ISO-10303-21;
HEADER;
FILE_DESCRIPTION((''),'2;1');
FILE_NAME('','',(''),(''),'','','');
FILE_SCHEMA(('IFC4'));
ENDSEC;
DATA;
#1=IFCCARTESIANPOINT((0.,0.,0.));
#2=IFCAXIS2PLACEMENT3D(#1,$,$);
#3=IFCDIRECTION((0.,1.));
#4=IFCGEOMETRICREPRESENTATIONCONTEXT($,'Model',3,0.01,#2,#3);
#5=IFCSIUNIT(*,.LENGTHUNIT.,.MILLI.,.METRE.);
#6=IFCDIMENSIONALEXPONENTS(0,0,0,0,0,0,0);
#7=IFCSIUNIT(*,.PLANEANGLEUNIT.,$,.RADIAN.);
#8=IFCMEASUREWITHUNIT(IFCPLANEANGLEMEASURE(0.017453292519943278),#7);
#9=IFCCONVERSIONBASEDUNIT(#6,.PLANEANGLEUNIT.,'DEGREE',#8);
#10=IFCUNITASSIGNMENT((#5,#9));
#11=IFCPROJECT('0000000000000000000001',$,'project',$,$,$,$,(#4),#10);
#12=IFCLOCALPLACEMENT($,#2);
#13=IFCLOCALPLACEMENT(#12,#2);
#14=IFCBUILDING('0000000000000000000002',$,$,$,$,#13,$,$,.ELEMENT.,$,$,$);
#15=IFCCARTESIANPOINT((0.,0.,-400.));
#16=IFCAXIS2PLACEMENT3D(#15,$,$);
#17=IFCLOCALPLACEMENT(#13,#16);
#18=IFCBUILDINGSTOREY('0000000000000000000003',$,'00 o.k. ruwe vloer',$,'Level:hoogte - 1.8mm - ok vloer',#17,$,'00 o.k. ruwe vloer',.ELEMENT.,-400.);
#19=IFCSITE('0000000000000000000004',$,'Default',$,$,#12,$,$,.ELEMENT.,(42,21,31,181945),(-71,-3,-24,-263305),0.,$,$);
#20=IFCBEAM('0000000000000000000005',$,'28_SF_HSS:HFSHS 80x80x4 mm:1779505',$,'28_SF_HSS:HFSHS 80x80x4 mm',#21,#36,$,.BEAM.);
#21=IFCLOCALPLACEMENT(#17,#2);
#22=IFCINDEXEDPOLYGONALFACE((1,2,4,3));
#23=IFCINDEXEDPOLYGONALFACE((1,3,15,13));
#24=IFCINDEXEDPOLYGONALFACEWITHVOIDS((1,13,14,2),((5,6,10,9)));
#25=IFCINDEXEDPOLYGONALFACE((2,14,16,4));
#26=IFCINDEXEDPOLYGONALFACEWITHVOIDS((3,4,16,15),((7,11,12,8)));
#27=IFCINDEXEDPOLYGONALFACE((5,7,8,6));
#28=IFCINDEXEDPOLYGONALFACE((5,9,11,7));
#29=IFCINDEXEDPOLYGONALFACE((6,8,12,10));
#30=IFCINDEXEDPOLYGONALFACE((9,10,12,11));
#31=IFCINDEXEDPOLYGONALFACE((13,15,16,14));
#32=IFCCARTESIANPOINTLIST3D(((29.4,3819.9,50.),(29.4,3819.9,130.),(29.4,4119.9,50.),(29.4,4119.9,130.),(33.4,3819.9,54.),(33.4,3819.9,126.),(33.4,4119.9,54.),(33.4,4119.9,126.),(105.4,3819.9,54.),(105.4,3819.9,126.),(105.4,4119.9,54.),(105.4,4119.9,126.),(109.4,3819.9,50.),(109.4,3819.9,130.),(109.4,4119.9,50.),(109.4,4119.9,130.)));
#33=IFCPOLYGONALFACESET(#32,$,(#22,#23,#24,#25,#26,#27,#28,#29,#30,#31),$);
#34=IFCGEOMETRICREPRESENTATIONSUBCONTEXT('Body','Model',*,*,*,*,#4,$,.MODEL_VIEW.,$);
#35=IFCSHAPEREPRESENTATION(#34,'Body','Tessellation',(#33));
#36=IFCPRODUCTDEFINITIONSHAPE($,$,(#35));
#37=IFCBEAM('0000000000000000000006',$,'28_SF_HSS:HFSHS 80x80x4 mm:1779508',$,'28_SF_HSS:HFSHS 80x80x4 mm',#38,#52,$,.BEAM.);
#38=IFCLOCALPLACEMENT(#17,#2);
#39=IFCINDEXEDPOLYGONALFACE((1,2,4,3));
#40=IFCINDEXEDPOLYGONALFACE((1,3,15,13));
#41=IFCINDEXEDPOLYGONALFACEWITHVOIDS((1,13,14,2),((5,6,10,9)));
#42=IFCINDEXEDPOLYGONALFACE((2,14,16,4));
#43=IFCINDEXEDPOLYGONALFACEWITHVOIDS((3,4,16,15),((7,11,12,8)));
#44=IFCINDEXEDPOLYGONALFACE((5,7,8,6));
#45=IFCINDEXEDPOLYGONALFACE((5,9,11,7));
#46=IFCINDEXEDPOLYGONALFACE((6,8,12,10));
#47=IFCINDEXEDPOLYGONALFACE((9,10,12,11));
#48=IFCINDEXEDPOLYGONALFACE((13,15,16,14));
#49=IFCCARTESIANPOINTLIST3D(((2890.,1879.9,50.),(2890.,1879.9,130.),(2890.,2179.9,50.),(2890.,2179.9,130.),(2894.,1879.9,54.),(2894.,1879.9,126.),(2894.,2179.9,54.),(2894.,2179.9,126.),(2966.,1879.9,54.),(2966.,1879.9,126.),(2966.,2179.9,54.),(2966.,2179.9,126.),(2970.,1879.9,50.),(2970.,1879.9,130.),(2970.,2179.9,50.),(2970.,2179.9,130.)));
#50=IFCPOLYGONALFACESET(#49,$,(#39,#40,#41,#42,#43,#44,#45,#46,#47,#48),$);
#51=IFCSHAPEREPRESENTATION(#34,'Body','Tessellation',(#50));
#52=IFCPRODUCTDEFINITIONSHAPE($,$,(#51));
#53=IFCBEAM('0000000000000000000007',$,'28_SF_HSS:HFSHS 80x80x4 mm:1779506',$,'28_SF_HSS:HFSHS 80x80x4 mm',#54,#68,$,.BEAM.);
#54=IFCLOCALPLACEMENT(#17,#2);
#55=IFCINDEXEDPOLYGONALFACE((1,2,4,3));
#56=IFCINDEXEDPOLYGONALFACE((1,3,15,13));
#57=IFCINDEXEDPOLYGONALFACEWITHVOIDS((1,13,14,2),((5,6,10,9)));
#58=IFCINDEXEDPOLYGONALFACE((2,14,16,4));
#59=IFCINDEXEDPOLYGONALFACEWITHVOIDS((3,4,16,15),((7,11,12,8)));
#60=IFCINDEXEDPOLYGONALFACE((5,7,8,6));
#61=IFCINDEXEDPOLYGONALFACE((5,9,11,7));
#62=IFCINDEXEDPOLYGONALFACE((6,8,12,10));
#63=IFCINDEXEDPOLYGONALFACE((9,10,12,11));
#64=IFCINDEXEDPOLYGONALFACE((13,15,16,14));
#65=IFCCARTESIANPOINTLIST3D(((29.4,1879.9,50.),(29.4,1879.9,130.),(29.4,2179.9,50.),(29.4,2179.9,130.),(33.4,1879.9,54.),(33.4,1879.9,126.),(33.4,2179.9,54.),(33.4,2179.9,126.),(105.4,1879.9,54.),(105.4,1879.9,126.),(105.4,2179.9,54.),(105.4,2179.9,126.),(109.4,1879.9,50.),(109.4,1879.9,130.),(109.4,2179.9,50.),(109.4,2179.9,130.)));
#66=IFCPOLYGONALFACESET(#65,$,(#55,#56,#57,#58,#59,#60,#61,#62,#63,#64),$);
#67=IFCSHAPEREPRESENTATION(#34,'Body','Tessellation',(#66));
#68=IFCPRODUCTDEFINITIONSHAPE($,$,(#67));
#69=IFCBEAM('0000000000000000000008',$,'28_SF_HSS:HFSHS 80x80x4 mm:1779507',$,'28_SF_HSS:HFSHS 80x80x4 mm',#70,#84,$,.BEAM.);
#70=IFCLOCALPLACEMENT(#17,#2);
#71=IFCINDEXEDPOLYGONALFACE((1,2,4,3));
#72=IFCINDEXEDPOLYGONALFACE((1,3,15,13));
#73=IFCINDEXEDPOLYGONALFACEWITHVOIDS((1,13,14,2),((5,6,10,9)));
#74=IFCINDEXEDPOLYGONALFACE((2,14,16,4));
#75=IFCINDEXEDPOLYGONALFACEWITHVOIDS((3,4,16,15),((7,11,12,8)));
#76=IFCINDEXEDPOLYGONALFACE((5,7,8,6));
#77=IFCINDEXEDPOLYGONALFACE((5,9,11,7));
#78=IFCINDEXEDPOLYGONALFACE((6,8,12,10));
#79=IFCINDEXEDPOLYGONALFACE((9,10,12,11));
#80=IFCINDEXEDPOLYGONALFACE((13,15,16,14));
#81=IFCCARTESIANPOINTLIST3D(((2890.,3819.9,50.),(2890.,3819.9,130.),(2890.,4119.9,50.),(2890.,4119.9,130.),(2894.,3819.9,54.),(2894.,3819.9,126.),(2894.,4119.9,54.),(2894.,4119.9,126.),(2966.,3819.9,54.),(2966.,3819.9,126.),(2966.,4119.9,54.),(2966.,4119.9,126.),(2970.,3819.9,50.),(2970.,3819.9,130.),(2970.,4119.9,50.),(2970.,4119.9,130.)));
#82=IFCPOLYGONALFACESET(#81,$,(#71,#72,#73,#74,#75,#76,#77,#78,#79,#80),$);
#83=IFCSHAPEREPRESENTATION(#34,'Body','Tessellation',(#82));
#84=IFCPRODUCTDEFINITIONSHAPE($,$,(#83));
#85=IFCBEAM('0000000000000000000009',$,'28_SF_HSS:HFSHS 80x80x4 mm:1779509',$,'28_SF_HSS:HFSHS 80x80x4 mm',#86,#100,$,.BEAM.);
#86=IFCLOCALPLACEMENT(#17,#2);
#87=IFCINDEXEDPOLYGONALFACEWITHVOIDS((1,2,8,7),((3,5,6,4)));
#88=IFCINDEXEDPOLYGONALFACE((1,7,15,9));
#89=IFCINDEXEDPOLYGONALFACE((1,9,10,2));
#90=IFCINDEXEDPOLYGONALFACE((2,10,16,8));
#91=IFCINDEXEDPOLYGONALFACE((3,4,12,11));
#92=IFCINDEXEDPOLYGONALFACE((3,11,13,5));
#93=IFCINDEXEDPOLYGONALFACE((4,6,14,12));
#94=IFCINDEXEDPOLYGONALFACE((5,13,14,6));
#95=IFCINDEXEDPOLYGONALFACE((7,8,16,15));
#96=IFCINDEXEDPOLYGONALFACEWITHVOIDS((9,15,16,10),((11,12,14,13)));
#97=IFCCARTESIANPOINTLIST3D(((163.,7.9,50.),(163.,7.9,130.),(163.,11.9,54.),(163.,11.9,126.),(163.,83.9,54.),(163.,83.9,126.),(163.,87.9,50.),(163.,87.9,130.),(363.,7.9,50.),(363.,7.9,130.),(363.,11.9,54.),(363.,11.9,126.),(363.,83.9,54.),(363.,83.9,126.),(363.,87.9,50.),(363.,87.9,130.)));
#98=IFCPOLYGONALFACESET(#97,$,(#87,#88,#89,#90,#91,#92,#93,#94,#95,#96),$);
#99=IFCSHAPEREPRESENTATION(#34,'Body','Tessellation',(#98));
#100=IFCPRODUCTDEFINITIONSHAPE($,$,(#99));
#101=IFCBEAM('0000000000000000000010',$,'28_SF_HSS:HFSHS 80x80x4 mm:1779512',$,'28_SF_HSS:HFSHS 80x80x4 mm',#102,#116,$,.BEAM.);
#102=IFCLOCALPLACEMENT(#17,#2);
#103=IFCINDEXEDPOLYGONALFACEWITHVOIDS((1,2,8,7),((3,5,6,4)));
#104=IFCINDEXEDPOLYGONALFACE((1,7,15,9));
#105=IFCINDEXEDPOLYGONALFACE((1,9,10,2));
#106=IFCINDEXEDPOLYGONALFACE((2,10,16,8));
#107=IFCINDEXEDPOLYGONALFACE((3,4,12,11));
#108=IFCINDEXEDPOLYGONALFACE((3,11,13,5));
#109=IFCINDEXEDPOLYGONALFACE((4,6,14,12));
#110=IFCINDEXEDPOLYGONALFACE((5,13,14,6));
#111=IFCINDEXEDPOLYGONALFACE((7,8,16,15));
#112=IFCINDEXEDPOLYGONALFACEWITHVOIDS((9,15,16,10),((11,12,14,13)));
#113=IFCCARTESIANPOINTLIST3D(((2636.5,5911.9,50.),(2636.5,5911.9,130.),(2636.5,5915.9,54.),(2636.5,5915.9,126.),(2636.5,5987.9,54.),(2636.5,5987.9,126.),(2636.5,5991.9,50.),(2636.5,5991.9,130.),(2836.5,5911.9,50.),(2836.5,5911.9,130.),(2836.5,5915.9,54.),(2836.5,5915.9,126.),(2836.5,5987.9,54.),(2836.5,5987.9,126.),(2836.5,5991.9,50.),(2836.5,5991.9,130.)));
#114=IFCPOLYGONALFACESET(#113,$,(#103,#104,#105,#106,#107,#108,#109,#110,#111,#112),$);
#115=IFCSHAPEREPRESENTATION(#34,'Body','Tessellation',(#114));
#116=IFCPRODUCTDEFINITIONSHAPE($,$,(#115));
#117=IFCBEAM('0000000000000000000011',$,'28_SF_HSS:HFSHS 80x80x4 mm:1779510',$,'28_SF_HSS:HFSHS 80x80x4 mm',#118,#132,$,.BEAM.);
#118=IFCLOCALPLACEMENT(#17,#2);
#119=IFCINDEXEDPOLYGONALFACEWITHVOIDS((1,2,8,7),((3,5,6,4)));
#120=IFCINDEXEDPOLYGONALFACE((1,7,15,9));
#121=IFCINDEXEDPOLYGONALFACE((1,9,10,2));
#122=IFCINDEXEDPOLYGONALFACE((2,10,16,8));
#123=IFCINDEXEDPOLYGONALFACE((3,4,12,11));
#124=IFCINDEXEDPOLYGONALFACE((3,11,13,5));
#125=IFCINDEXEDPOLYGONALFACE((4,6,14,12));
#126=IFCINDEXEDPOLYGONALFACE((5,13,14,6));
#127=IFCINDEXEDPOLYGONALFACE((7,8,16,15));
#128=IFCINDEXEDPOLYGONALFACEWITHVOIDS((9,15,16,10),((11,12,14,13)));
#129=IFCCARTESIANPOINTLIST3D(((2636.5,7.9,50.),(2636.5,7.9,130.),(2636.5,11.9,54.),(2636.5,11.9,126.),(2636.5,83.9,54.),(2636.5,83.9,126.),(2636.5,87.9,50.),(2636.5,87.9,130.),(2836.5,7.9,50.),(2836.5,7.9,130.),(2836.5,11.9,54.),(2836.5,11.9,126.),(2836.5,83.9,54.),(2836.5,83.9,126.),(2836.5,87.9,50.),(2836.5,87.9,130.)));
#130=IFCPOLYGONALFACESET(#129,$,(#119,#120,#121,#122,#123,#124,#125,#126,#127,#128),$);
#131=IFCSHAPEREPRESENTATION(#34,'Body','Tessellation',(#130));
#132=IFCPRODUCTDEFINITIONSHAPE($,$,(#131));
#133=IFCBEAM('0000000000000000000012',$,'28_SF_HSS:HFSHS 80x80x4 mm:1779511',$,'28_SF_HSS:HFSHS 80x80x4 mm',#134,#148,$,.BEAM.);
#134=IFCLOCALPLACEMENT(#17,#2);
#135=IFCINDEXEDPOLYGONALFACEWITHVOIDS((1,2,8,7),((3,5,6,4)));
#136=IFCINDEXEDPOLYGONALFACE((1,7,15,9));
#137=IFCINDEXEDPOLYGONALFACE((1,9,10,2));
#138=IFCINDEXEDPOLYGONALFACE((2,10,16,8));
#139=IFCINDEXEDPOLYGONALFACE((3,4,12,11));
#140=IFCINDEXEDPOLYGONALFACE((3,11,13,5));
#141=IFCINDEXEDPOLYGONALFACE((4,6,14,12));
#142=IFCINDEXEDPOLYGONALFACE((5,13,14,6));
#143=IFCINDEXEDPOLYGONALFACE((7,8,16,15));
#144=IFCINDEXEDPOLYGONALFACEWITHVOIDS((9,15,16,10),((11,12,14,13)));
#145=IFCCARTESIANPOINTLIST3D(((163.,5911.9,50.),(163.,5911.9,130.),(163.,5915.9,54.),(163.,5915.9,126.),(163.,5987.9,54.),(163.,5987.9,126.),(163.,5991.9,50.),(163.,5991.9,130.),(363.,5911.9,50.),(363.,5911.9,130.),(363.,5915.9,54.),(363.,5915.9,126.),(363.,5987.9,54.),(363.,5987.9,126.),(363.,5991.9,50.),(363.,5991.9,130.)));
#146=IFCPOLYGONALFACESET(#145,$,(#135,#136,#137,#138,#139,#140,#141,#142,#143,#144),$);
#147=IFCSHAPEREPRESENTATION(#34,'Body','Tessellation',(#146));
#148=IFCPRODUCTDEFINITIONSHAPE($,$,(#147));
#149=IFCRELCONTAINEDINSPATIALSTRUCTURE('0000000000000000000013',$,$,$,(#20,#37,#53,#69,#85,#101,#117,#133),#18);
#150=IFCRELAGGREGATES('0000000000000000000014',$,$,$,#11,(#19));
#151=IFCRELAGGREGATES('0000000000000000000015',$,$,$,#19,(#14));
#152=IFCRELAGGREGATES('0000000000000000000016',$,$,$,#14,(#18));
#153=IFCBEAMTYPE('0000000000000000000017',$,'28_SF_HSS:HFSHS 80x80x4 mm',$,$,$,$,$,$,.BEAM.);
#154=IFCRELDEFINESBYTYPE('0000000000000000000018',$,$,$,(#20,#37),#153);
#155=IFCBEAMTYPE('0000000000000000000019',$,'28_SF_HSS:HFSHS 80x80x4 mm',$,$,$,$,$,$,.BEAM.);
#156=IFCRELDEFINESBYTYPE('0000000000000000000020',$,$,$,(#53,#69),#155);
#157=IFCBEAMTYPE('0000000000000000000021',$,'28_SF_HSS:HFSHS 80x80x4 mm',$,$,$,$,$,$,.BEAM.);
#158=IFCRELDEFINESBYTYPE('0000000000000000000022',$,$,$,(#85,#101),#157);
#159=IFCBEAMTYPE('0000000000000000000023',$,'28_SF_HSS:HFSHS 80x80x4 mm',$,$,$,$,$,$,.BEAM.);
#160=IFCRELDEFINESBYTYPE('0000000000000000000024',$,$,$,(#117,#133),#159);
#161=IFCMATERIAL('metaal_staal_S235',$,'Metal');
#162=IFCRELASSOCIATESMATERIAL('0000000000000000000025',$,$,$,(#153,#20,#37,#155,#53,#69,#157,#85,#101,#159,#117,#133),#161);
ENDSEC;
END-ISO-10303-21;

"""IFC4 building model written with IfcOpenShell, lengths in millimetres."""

from ifc_helpers import new_model, entity, si_unit, converted_unit, direction, frame, origin, place, context, subcontext, project, spatial, indexed_curve, outline, extrude, source, transform, mapped, material, type_object, type_shapes, element, save


model = new_model("IFC4")

# Units and contexts
model_context = context("Model", 3, precision=0.01, world=origin(), true_north=direction((0.0, 1.0)))
body_context = subcontext(model_context, "Body", "Model", "MODEL_VIEW")
ifc_project = project(units=[si_unit("LENGTHUNIT", "METRE", prefix="MILLI"), converted_unit("PLANEANGLEUNIT", "DEGREE", entity("IfcPlaneAngleMeasure", 0.017453292519943278), si_unit("PLANEANGLEUNIT", "RADIAN"), dimensions=[0, 0, 0, 0, 0, 0, 0])], contexts=[model_context])

# Site, building, storey
site_placement = place(None, origin())
site = spatial("IfcSite", under=ifc_project, at=site_placement, Name="Default", CompositionType="ELEMENT", RefLatitude=(42, 21, 31, 181945), RefLongitude=(-71, -3, -24, -263305), RefElevation=0.0)
building_placement = place(site_placement, origin())
building = spatial("IfcBuilding", under=site, at=building_placement, CompositionType="ELEMENT")
storey_placement = place(building_placement, frame((0.0, 0.0, -400.0)))
storey = spatial("IfcBuildingStorey", under=building, at=storey_placement, Name="00 o.k. ruwe vloer", ObjectType="Level:hoogte - 1.8mm - ok vloer", LongName="00 o.k. ruwe vloer", CompositionType="ELEMENT", Elevation=-400.0)

# Shared definitions
ifc_material = material(Name="metaal_staal_S235", Category="Metal")

# Beams
beam_type_1 = type_object("IfcBeamType", Name="28_SF_HSS:HFSHS 80x80x4 mm", PredefinedType="BEAM", material=ifc_material)
shared_shape_1 = source(origin(), body_context, "Body", "SweptSolid", [
    extrude(outline(indexed_curve([(-40.0, -40.0), (40.0, -40.0), (40.0, 40.0), (-40.0, 40.0), (-40.0, -40.0)], self_intersect=False), holes=[indexed_curve([(-36.0, -36.0), (-36.0, 36.0), (36.0, 36.0), (36.0, -36.0), (-36.0, -36.0)], self_intersect=False)]), frame((-150.0, 0.0, 0.0), z_axis=(1.0, 0.0, 0.0), x_axis=(0.0, -1.0, 0.0)), (0.0, 0.0, 1.0), 300.0),
])
type_shapes(beam_type_1, [shared_shape_1])
for number, where, z_axis, x_axis, name in (
    (1, (69.4, 3969.9, 90.0), (0.0, 0.0, 1.0), (0.0, 1.0, 0.0), "28_SF_HSS:HFSHS 80x80x4 mm:1779505"),
    (2, (2930.0, 2029.9, 90.0), (0.0, 0.0, 1.0), (0.0, -1.0, 0.0), "28_SF_HSS:HFSHS 80x80x4 mm:1779508"),
):
    element("IfcBeam", number, at=place(storey_placement, frame(where, z_axis=z_axis, x_axis=x_axis)), inside=storey, type_object=beam_type_1, material=ifc_material, Name=name, ObjectType="28_SF_HSS:HFSHS 80x80x4 mm", PredefinedType="BEAM", context=body_context, shape_type="MappedRepresentation", body=[
        mapped(shared_shape_1, transform((0.0, 0.0, 0.0), scale=1.0)),
    ])
beam_type_2 = type_object("IfcBeamType", Name="28_SF_HSS:HFSHS 80x80x4 mm", PredefinedType="BEAM", material=ifc_material)
shared_shape_2 = source(origin(), body_context, "Body", "SweptSolid", [
    extrude(outline(indexed_curve([(-40.0, -40.0), (40.0, -40.0), (40.0, 40.0), (-40.0, 40.0), (-40.0, -40.0)], self_intersect=False), holes=[indexed_curve([(-36.0, -36.0), (-36.0, 36.0), (36.0, 36.0), (36.0, -36.0), (-36.0, -36.0)], self_intersect=False)]), frame((-150.0, 0.0, 0.0), z_axis=(1.0, 0.0, 0.0), x_axis=(0.0, 0.0, -1.0)), (0.0, 0.0, 1.0), 300.0),
])
type_shapes(beam_type_2, [shared_shape_2])
for number, where, z_axis, x_axis, name in (
    (3, (69.4, 2029.9, 90.0), (0.0, 0.0, 1.0), (0.0, -1.0, 0.0), "28_SF_HSS:HFSHS 80x80x4 mm:1779506"),
    (4, (2930.0, 3969.9, 90.0), (0.0, 0.0, 1.0), (0.0, 1.0, 0.0), "28_SF_HSS:HFSHS 80x80x4 mm:1779507"),
):
    element("IfcBeam", number, at=place(storey_placement, frame(where, z_axis=z_axis, x_axis=x_axis)), inside=storey, type_object=beam_type_2, material=ifc_material, Name=name, ObjectType="28_SF_HSS:HFSHS 80x80x4 mm", PredefinedType="BEAM", context=body_context, shape_type="MappedRepresentation", body=[
        mapped(shared_shape_2, transform((0.0, 0.0, 0.0), scale=1.0)),
    ])
beam_type_3 = type_object("IfcBeamType", Name="28_SF_HSS:HFSHS 80x80x4 mm", PredefinedType="BEAM", material=ifc_material)
shared_shape_3 = source(origin(), body_context, "Body", "SweptSolid", [
    extrude(outline(indexed_curve([(-40.0, -40.0), (40.0, -40.0), (40.0, 40.0), (-40.0, 40.0), (-40.0, -40.0)], self_intersect=False), holes=[indexed_curve([(-36.0, -36.0), (-36.0, 36.0), (36.0, 36.0), (36.0, -36.0), (-36.0, -36.0)], self_intersect=False)]), frame((-100.0, 0.0, 0.0), z_axis=(1.0, 0.0, 0.0), x_axis=(0.0, -1.0, 0.0)), (0.0, 0.0, 1.0), 200.0),
])
type_shapes(beam_type_3, [shared_shape_3])
beam_1_placement = place(storey_placement, frame((263.0, 47.9, 90.0), z_axis=(0.0, 0.0, 1.0), x_axis=(-1.0, 0.0, 0.0)))
element("IfcBeam", 5, at=beam_1_placement, inside=storey, type_object=beam_type_3, material=ifc_material, Name="28_SF_HSS:HFSHS 80x80x4 mm:1779509", ObjectType="28_SF_HSS:HFSHS 80x80x4 mm", PredefinedType="BEAM", context=body_context, shape_type="MappedRepresentation", body=[
    mapped(shared_shape_3, transform((0.0, 0.0, 0.0), scale=1.0)),
])
beam_2_placement = place(storey_placement, frame((2736.5, 5951.9, 90.0)))
element("IfcBeam", 6, at=beam_2_placement, inside=storey, type_object=beam_type_3, material=ifc_material, Name="28_SF_HSS:HFSHS 80x80x4 mm:1779512", ObjectType="28_SF_HSS:HFSHS 80x80x4 mm", PredefinedType="BEAM", context=body_context, shape_type="MappedRepresentation", body=[
    mapped(shared_shape_3, transform((0.0, 0.0, 0.0), scale=1.0)),
])
beam_type_4 = type_object("IfcBeamType", Name="28_SF_HSS:HFSHS 80x80x4 mm", PredefinedType="BEAM", material=ifc_material)
shared_shape_4 = source(origin(), body_context, "Body", "SweptSolid", [
    extrude(outline(indexed_curve([(-40.0, -40.0), (40.0, -40.0), (40.0, 40.0), (-40.0, 40.0), (-40.0, -40.0)], self_intersect=False), holes=[indexed_curve([(-36.0, -36.0), (-36.0, 36.0), (36.0, 36.0), (36.0, -36.0), (-36.0, -36.0)], self_intersect=False)]), frame((-100.0, 0.0, 0.0), z_axis=(1.0, 0.0, 0.0), x_axis=(0.0, 0.0, -1.0)), (0.0, 0.0, 1.0), 200.0),
])
type_shapes(beam_type_4, [shared_shape_4])
beam_3_placement = place(storey_placement, frame((2736.5, 47.9, 90.0)))
element("IfcBeam", 7, at=beam_3_placement, inside=storey, type_object=beam_type_4, material=ifc_material, Name="28_SF_HSS:HFSHS 80x80x4 mm:1779510", ObjectType="28_SF_HSS:HFSHS 80x80x4 mm", PredefinedType="BEAM", context=body_context, shape_type="MappedRepresentation", body=[
    mapped(shared_shape_4, transform((0.0, 0.0, 0.0), scale=1.0)),
])
beam_4_placement = place(storey_placement, frame((263.0, 5951.9, 90.0), z_axis=(0.0, 0.0, 1.0), x_axis=(-1.0, 0.0, 0.0)))
element("IfcBeam", 8, at=beam_4_placement, inside=storey, type_object=beam_type_4, material=ifc_material, Name="28_SF_HSS:HFSHS 80x80x4 mm:1779511", ObjectType="28_SF_HSS:HFSHS 80x80x4 mm", PredefinedType="BEAM", context=body_context, shape_type="MappedRepresentation", body=[
    mapped(shared_shape_4, transform((0.0, 0.0, 0.0), scale=1.0)),
])

save(model, "model.ifc")
